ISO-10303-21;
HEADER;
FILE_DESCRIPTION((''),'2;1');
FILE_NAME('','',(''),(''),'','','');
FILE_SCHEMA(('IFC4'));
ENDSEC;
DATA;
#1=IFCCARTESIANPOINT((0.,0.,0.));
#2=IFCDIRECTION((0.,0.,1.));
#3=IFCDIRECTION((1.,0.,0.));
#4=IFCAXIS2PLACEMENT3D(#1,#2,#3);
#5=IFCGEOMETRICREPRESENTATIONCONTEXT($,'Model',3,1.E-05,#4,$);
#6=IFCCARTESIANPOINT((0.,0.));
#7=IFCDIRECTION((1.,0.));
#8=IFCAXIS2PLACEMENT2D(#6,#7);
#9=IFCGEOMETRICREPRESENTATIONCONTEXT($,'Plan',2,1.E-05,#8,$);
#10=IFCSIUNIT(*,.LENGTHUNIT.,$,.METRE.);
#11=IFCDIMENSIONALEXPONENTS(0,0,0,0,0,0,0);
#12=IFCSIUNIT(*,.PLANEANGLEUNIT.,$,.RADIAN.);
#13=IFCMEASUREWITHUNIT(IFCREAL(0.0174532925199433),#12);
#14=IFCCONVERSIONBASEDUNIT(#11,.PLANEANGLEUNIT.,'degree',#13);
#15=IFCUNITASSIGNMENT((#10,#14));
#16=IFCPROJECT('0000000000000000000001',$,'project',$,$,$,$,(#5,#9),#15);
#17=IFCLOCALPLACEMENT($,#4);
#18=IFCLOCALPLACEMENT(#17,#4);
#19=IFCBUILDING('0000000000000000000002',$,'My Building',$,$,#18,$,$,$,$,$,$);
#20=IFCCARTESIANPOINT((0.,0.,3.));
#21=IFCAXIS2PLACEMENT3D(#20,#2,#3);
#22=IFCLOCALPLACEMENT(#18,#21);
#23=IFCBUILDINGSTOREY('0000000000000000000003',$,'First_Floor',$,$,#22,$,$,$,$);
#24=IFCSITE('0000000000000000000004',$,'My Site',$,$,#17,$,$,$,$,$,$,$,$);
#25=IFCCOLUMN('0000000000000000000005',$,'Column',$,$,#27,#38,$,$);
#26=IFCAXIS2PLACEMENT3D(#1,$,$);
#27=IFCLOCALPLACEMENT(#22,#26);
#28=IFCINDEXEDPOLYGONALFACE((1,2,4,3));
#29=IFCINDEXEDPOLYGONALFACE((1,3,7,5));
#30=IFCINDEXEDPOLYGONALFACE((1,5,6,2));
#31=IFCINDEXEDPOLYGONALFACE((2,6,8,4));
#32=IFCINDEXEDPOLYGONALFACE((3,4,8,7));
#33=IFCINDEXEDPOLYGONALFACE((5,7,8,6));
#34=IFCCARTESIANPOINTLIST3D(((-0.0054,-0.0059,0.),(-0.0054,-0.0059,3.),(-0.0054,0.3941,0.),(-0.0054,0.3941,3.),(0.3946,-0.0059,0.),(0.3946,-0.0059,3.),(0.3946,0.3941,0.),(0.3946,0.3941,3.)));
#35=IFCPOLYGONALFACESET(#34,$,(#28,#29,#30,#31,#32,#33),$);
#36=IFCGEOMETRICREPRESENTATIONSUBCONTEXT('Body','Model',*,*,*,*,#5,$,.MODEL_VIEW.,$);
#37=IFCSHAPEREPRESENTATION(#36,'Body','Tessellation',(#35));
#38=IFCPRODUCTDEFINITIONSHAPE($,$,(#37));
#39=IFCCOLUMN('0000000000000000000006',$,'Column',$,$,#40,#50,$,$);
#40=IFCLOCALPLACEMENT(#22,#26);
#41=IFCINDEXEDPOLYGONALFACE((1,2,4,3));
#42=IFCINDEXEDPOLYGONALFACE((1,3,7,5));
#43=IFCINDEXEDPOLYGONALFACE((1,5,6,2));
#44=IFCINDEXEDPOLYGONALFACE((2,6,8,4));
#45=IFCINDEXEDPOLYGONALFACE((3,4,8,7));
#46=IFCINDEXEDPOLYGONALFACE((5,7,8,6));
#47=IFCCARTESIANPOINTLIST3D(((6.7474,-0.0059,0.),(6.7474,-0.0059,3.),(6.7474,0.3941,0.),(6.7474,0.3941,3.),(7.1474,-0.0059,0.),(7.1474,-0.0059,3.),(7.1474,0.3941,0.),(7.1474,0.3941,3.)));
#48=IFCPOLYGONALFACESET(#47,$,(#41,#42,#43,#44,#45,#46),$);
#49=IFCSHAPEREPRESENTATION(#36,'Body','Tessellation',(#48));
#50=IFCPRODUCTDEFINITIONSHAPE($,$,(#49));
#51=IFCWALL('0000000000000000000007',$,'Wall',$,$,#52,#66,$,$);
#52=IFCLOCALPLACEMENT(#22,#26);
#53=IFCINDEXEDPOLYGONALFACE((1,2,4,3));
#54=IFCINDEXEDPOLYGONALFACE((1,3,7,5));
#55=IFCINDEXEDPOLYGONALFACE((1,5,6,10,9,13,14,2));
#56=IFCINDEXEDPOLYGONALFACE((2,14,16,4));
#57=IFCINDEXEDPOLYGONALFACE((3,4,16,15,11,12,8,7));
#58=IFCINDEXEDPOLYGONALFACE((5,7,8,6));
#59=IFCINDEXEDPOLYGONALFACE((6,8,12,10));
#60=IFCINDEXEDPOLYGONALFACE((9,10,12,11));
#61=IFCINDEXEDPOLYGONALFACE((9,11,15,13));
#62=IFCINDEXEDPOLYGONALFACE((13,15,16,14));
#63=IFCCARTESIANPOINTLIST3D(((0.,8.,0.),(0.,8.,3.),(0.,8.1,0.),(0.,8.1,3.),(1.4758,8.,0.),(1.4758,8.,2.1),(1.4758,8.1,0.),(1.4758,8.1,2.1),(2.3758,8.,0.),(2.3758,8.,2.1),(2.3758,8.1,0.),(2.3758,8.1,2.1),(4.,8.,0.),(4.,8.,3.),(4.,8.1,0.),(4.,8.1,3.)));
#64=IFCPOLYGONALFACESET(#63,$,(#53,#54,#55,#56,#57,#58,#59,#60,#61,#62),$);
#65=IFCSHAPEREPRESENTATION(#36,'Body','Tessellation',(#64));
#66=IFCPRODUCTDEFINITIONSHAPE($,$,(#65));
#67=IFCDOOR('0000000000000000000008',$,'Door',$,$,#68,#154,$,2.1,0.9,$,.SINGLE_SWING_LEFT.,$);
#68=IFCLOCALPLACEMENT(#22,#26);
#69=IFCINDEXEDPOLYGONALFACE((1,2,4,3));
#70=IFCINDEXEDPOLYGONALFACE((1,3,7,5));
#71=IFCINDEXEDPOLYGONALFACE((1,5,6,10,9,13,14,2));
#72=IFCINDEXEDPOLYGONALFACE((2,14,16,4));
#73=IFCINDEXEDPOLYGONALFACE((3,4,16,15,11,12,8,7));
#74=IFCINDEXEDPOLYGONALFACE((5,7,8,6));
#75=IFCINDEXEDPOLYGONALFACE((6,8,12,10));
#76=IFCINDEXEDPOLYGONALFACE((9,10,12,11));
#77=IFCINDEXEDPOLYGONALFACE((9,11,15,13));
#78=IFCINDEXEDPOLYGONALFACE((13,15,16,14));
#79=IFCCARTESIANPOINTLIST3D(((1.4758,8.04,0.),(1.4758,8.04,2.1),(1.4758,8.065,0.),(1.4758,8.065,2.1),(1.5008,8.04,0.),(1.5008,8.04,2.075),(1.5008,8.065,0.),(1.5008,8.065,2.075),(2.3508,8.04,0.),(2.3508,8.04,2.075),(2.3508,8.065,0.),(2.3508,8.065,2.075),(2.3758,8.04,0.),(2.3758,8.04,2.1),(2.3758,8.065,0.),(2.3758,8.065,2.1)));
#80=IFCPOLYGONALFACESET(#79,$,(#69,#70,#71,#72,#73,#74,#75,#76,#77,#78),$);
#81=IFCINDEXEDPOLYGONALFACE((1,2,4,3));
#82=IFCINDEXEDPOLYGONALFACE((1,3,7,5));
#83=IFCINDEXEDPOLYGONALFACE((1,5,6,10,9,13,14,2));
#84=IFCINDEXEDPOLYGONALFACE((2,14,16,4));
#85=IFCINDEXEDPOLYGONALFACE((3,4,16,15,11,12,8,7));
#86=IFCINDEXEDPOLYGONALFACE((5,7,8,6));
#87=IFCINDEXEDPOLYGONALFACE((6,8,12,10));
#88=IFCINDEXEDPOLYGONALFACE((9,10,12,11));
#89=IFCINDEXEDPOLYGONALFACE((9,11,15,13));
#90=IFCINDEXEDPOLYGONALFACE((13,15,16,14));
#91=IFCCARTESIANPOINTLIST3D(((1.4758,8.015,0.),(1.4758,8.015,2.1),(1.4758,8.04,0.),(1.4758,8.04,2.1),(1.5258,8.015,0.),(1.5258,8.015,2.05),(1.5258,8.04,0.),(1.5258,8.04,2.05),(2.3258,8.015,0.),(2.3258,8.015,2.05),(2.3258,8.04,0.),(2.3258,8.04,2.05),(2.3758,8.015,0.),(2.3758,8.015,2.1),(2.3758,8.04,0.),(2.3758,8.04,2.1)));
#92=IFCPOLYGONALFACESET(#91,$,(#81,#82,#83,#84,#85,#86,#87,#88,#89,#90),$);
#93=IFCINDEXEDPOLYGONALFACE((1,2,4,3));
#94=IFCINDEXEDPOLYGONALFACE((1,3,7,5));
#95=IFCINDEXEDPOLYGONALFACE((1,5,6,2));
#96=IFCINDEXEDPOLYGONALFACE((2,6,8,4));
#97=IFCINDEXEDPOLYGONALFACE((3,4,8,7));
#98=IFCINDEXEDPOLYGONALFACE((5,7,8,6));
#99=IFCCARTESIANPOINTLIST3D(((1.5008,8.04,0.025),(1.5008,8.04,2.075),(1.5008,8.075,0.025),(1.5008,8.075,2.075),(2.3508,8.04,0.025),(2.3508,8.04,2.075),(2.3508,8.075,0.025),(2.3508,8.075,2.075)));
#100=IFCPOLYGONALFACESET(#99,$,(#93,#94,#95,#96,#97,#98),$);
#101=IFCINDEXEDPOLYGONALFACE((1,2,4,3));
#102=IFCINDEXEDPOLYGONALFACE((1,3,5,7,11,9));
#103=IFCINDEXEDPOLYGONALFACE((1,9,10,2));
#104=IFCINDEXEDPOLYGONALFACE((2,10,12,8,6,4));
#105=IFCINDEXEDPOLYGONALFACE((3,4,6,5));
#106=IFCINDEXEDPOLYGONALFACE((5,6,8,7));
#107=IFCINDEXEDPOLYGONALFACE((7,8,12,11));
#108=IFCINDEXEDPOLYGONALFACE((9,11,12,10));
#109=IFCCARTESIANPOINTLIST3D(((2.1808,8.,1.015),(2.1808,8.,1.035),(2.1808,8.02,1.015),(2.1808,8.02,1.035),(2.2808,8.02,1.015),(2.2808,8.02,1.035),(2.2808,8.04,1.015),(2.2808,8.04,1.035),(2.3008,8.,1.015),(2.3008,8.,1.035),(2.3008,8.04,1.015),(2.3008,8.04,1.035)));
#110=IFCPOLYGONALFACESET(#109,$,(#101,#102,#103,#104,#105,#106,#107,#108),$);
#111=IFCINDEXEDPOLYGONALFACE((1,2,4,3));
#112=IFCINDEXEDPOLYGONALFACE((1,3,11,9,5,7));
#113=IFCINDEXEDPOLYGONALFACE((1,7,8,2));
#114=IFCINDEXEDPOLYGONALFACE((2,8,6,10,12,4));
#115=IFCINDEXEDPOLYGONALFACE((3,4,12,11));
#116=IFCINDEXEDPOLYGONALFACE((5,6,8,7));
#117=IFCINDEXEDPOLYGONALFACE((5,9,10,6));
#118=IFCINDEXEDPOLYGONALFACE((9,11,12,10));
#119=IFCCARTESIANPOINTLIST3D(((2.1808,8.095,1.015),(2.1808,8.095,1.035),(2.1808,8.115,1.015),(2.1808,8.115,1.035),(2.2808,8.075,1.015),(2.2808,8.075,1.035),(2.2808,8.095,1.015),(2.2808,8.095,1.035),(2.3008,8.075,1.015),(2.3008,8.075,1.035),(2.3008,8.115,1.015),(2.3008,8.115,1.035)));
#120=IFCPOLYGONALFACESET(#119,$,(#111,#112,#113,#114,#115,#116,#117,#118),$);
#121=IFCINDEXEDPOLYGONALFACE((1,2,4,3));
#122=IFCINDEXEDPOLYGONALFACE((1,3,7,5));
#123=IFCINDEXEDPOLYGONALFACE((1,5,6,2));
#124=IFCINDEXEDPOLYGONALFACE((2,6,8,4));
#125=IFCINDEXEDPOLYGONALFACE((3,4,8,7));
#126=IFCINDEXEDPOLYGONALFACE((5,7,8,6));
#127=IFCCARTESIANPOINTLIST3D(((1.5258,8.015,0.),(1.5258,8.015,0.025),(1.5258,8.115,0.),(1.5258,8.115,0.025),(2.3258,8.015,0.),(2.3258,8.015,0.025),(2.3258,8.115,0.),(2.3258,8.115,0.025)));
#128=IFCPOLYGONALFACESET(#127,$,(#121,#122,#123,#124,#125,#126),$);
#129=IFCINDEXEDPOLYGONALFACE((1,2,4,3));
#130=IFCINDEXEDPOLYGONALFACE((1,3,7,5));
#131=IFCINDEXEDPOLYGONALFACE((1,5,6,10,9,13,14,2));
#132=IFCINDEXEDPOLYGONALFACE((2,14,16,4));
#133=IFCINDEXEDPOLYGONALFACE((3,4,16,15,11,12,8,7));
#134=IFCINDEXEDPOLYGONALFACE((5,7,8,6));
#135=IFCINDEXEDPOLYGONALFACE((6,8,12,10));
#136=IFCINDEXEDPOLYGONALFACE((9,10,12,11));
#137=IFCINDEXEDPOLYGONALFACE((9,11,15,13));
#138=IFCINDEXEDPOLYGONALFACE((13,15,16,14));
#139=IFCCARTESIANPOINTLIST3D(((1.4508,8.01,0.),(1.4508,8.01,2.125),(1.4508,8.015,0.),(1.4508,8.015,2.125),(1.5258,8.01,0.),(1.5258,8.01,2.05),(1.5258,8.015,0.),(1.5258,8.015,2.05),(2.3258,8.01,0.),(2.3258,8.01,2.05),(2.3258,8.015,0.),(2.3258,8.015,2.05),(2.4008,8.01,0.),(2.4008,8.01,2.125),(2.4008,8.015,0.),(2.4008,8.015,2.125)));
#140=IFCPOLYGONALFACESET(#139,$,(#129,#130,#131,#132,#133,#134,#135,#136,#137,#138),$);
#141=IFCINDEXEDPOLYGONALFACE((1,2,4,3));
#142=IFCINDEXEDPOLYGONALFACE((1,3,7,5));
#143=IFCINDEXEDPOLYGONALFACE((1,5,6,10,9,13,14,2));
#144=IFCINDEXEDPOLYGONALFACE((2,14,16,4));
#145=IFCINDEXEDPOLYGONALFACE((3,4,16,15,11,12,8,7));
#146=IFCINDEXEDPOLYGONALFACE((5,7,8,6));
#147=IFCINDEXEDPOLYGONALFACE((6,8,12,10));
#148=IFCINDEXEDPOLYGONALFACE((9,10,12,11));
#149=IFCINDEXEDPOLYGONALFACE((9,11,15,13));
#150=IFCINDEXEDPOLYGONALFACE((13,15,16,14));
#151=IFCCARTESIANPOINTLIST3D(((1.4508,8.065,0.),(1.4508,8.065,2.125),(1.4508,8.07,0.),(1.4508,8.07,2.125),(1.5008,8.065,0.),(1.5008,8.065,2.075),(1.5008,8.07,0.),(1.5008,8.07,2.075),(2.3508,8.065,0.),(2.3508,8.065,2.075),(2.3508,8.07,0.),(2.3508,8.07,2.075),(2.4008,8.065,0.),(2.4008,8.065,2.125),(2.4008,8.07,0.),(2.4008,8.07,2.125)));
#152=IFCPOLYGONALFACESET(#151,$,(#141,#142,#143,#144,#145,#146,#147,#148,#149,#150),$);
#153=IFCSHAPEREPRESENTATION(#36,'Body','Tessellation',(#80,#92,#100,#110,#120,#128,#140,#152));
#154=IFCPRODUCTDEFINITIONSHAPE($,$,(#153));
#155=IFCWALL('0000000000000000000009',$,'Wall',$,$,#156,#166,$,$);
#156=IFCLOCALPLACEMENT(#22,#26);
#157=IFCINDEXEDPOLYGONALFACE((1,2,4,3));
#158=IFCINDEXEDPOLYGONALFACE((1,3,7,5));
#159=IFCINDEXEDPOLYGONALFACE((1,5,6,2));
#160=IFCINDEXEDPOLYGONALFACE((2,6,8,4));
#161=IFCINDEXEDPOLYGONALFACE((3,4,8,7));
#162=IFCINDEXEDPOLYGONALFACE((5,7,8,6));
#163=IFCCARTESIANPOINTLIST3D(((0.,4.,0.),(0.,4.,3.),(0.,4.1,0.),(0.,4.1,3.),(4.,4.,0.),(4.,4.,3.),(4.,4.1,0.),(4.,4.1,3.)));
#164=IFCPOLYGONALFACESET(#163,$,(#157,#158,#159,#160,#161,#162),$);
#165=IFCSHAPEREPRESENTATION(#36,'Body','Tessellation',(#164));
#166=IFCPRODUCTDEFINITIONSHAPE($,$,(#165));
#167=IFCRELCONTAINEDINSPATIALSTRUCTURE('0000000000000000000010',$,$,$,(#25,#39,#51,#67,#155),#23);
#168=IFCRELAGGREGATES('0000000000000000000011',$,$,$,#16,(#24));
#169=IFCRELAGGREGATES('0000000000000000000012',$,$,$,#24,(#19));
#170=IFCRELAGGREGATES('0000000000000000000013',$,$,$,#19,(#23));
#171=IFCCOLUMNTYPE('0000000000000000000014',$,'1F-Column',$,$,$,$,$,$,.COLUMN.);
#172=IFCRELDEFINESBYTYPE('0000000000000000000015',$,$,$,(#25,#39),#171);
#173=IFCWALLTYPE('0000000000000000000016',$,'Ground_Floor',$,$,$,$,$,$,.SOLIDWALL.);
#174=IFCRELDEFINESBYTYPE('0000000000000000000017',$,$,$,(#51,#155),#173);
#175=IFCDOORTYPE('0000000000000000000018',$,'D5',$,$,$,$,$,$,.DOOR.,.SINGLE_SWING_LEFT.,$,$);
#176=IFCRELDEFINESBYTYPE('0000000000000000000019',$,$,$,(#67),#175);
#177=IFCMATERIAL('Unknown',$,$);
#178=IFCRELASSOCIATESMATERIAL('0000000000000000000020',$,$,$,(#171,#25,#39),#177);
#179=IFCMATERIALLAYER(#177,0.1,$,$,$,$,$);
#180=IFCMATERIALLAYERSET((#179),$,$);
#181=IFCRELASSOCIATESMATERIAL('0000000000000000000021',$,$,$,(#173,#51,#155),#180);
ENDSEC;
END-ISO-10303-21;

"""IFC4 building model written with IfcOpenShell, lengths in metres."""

from ifc_helpers import new_model, entity, si_unit, converted_unit, frame, origin_with_axes, origin_2d_with_axis, place, context, subcontext, project, spatial, line, indexed_curve, rectangle, outline, extrude, shape, source, transform, mapped, material, layer, layer_set, layer_usage, material_profile, profile_set, profile_usage, type_object, type_shapes, element, fill, save


model = new_model("IFC4")

# Units and contexts
model_context = context("Model", 3, precision=1e-05, world=origin_with_axes())
plan_context = context("Plan", 2, precision=1e-05, world=origin_2d_with_axis())
body_context_1 = subcontext(model_context, "Body", "Model", "MODEL_VIEW")
body_context_2 = subcontext(plan_context, "Body", "Plan", "PLAN_VIEW")
ifc_project = project(units=[si_unit("LENGTHUNIT", "METRE"), converted_unit("PLANEANGLEUNIT", "degree", entity("IfcReal", 0.0174532925199433), si_unit("PLANEANGLEUNIT", "RADIAN"), dimensions=[0, 0, 0, 0, 0, 0, 0])], contexts=[model_context, plan_context])

# Site, building, storey
site_placement = place(None, origin_with_axes())
site = spatial("IfcSite", under=ifc_project, at=site_placement, Name="My Site")
building_placement = place(site_placement, origin_with_axes())
building = spatial("IfcBuilding", under=site, at=building_placement, Name="My Building")
storey_placement = place(building_placement, frame((0.0, 0.0, 3.0), z_axis=(0.0, 0.0, 1.0), x_axis=(1.0, 0.0, 0.0)))
storey = spatial("IfcBuildingStorey", under=building, at=storey_placement, Name="First_Floor")

# Columns
ifc_material = material(Name="Unknown")
ifc_material_profile = material_profile(ifc_material, rectangle(XDim=0.4, YDim=0.4))
ifc_profile_set = profile_set([ifc_material_profile])
ifc_profile_usage_1 = profile_usage(ifc_profile_set, cardinal=5)
column_type = type_object("IfcColumnType", Name="1F-Column", PredefinedType="COLUMN", material=ifc_profile_set)
column_1_placement = place(storey_placement, frame((0.1946, 0.1941, 0.0), z_axis=(0.0, 0.0, 1.0), x_axis=(1.0, 0.0, 0.0)))
element("IfcColumn", 1, at=column_1_placement, inside=storey, type_object=column_type, material=ifc_profile_usage_1, Name="Column", context=body_context_1, shape_type="SweptSolid", body=[
    extrude(rectangle(XDim=0.4, YDim=0.4), origin_with_axes(), (0.0, 0.0, 1.0), 3.0),
])
ifc_profile_usage_2 = profile_usage(ifc_profile_set, cardinal=5)
column_2_placement = place(storey_placement, frame((6.9474, 0.1941, 0.0), z_axis=(0.0, 0.0, 1.0), x_axis=(1.0, 0.0, 0.0)))
element("IfcColumn", 2, at=column_2_placement, inside=storey, type_object=column_type, material=ifc_profile_usage_2, Name="Column", context=body_context_1, shape_type="SweptSolid", body=[
    extrude(rectangle(XDim=0.4, YDim=0.4), origin_with_axes(), (0.0, 0.0, 1.0), 3.0),
])

# Wall, opening, door
ifc_layer = layer(ifc_material, 0.1)
ifc_layer_set = layer_set([ifc_layer])
ifc_layer_usage_1 = layer_usage(ifc_layer_set, "AXIS2", "POSITIVE", 0.0)
wall_type = type_object("IfcWallType", Name="Ground_Floor", PredefinedType="SOLIDWALL", material=ifc_layer_set)
wall_1_placement = place(storey_placement, frame((0.0, 8.0, 0.0), z_axis=(0.0, 0.0, 1.0), x_axis=(1.0, 0.0, 0.0)))
wall_1 = element("IfcWall", 3, at=wall_1_placement, inside=storey, type_object=wall_type, material=ifc_layer_usage_1, Name="Wall", context=body_context_1, shape_type="SweptSolid", body=[
    extrude(outline(indexed_curve([(0.0, 0.0), (0.0, 0.1), (4.0, 0.1), (4.0, 0.0)], segments=[line(1, 2, 3, 4, 1)])), origin_with_axes(), (0.0, 0.0, 1.0), 3.0),
])
shared_shape_1 = source(origin_with_axes(), body_context_1, "Body", "SweptSolid", [
    extrude(outline(indexed_curve([(0.0, 0.0), (0.9, 0.0), (0.9, 2.1), (0.0, 2.1)], segments=[line(1, 2, 3, 4, 1)])), frame((0.0, -0.6, 0.0), z_axis=(0.0, -1.0, 0.0), x_axis=(1.0, 0.0, 0.0)), (0.0, 0.0, -1.0), 1.2),
])
opening_1_placement = place(wall_1_placement, frame((1.4758, 0.015, 0.0), z_axis=(0.0, 0.0, 1.0), x_axis=(1.0, 0.0, 0.0)))
opening_1 = element("IfcOpeningElement", 4, at=opening_1_placement, cuts=wall_1, PredefinedType="OPENING", context=body_context_1, shape_type="MappedRepresentation", body=[
    mapped(shared_shape_1, transform((0.0, 0.0, 0.0), x_axis=(1.0, 0.0, 0.0), y_axis=(0.0, 1.0, 0.0), z_axis=(0.0, 0.0, 1.0), scale=1.0)),
])
door_type_1 = type_object("IfcDoorType", Name="D5", OperationType="SINGLE_SWING_LEFT", PredefinedType="DOOR")
shared_shape_2 = source(origin_with_axes(), body_context_1, "Body", "SweptSolid", [
    extrude(outline(indexed_curve([(0.0, 0.0), (0.0, 2.1), (0.9, 2.1), (0.9, 0.0), (0.875, 0.0), (0.875, 2.075), (0.025, 2.075), (0.025, 0.0)], segments=[line(1, 2, 3, 4, 5, 6, 7, 8, 1)])), frame((0.0, 0.025, 0.0), z_axis=(0.0, -1.0, 0.0), x_axis=(1.0, 0.0, 0.0)), (0.0, 0.0, -1.0), 0.025),
    extrude(outline(indexed_curve([(0.0, 0.0), (0.0, 2.1), (0.9, 2.1), (0.9, 0.0), (0.85, 0.0), (0.85, 2.05), (0.05, 2.05), (0.05, 0.0)], segments=[line(1, 2, 3, 4, 5, 6, 7, 8, 1)])), frame((0.0, 0.0, 0.0), z_axis=(0.0, -1.0, 0.0), x_axis=(1.0, 0.0, 0.0)), (0.0, 0.0, -1.0), 0.025),
    extrude(outline(indexed_curve([(0.0, 0.0), (0.85, 0.0), (0.85, 0.035), (0.0, 0.035)], segments=[line(1, 2, 3, 4, 1)])), frame((0.025, 0.025, 0.025), z_axis=(0.0, 0.0, 1.0), x_axis=(1.0, 0.0, 0.0)), (0.0, 0.0, 1.0), 2.05),
    extrude(outline(indexed_curve([(0.0, 0.0), (0.0, -0.04), (-0.12, -0.04), (-0.12, -0.02), (-0.02, -0.02), (-0.02, 0.0)], segments=[line(1, 2, 3, 4, 5, 6, 1)])), frame((0.825, 0.025, 1.015), z_axis=(0.0, 0.0, 1.0), x_axis=(1.0, 0.0, 0.0)), (0.0, 0.0, 1.0), 0.02),
    extrude(outline(indexed_curve([(0.0, 0.0), (0.0, 0.04), (-0.12, 0.04), (-0.12, 0.02), (-0.02, 0.02), (-0.02, 0.0)], segments=[line(1, 2, 3, 4, 5, 6, 1)])), frame((0.825, 0.06, 1.015), z_axis=(0.0, 0.0, 1.0), x_axis=(1.0, 0.0, 0.0)), (0.0, 0.0, 1.0), 0.02),
    extrude(outline(indexed_curve([(0.0, 0.0), (0.8, 0.0), (0.8, 0.1), (0.0, 0.1)], segments=[line(1, 2, 3, 4, 1)])), frame((0.05, 0.0, 0.0), z_axis=(0.0, 0.0, 1.0), x_axis=(1.0, 0.0, 0.0)), (0.0, 0.0, 1.0), 0.025),
    extrude(outline(indexed_curve([(0.0, 0.0), (0.0, 2.125), (0.95, 2.125), (0.95, 0.0), (0.875, 0.0), (0.875, 2.05), (0.075, 2.05), (0.075, 0.0)], segments=[line(1, 2, 3, 4, 5, 6, 7, 8, 1)])), frame((-0.025, -0.005, 0.0), z_axis=(0.0, -1.0, 0.0), x_axis=(1.0, 0.0, 0.0)), (0.0, 0.0, -1.0), 0.005),
    extrude(outline(indexed_curve([(0.0, 0.0), (0.0, 2.125), (0.95, 2.125), (0.95, 0.0), (0.9, 0.0), (0.9, 2.075), (0.05, 2.075), (0.05, 0.0)], segments=[line(1, 2, 3, 4, 5, 6, 7, 8, 1)])), frame((-0.025, 0.05, 0.0), z_axis=(0.0, -1.0, 0.0), x_axis=(1.0, 0.0, 0.0)), (0.0, 0.0, -1.0), 0.005),
])
shared_shape_3 = source(origin_with_axes(), body_context_2, "Body", "Curve2D", [
    entity("IfcIndexedPolyCurve", entity("IfcCartesianPointList2D", [[0.0, 0.0], [0.0, 0.05], [0.025, 0.05], [0.025, 0.025], [0.05, 0.025], [0.05, 0.0]]), [entity("IfcLineIndex", [1, 2, 3, 4, 5, 6, 1])]),
    entity("IfcIndexedPolyCurve", entity("IfcCartesianPointList2D", [[0.9, 0.0], [0.9, 0.05], [0.875, 0.05], [0.875, 0.025], [0.85, 0.025], [0.85, 0.0]]), [entity("IfcLineIndex", [1, 2, 3, 4, 5, 6, 1])]),
    entity("IfcTrimmedCurve", entity("IfcEllipse", entity("IfcAxis2Placement2D", entity("IfcCartesianPoint", [0.06, 0.05]), entity("IfcDirection", [1.0, 0.0])), 0.815, 0.85), [entity("IfcCartesianPoint", [0.875, 0.05])], [entity("IfcCartesianPoint", [0.06, 0.9])], True, "CARTESIAN"),
    entity("IfcIndexedPolyCurve", entity("IfcCartesianPointList2D", [[0.025, 0.05], [0.06, 0.05], [0.06, 0.9], [0.025, 0.9]]), [entity("IfcLineIndex", [1, 2, 3, 4, 1])]),
])
type_shapes(door_type_1, [shared_shape_2, shared_shape_3])
door_1_placement = place(opening_1_placement, origin_with_axes())
door_1 = element("IfcDoor", 5, at=door_1_placement, inside=storey, type_object=door_type_1, Name="Door", OperationType="SINGLE_SWING_LEFT", OverallHeight=2.1, OverallWidth=0.9, shapes=[
    shape(body_context_1, "Body", "MappedRepresentation", [mapped(shared_shape_2, transform((0.0, 0.0, 0.0), x_axis=(1.0, 0.0, 0.0), y_axis=(0.0, 1.0, 0.0), z_axis=(0.0, 0.0, 1.0), scale=1.0))]),
    shape(body_context_2, "Body", "MappedRepresentation", [mapped(shared_shape_3, transform((0.0, 0.0, 0.0), x_axis=(1.0, 0.0, 0.0), y_axis=(0.0, 1.0, 0.0), z_axis=(0.0, 0.0, 1.0), scale=1.0))]),
])
fill(opening_1, door_1)

# Wall
ifc_layer_usage_2 = layer_usage(ifc_layer_set, "AXIS2", "POSITIVE", 0.0)
wall_2_placement = place(storey_placement, frame((0.0, 4.0, 0.0), z_axis=(0.0, 0.0, 1.0), x_axis=(1.0, 0.0, 0.0)))
element("IfcWall", 6, at=wall_2_placement, inside=storey, type_object=wall_type, material=ifc_layer_usage_2, Name="Wall", context=body_context_1, shape_type="SweptSolid", body=[
    extrude(outline(indexed_curve([(0.0, 0.0), (0.0, 0.1), (4.0, 0.1), (4.0, 0.0)], segments=[line(1, 2, 3, 4, 1)])), origin_with_axes(), (0.0, 0.0, 1.0), 3.0),
])

save(model, "model.ifc")
